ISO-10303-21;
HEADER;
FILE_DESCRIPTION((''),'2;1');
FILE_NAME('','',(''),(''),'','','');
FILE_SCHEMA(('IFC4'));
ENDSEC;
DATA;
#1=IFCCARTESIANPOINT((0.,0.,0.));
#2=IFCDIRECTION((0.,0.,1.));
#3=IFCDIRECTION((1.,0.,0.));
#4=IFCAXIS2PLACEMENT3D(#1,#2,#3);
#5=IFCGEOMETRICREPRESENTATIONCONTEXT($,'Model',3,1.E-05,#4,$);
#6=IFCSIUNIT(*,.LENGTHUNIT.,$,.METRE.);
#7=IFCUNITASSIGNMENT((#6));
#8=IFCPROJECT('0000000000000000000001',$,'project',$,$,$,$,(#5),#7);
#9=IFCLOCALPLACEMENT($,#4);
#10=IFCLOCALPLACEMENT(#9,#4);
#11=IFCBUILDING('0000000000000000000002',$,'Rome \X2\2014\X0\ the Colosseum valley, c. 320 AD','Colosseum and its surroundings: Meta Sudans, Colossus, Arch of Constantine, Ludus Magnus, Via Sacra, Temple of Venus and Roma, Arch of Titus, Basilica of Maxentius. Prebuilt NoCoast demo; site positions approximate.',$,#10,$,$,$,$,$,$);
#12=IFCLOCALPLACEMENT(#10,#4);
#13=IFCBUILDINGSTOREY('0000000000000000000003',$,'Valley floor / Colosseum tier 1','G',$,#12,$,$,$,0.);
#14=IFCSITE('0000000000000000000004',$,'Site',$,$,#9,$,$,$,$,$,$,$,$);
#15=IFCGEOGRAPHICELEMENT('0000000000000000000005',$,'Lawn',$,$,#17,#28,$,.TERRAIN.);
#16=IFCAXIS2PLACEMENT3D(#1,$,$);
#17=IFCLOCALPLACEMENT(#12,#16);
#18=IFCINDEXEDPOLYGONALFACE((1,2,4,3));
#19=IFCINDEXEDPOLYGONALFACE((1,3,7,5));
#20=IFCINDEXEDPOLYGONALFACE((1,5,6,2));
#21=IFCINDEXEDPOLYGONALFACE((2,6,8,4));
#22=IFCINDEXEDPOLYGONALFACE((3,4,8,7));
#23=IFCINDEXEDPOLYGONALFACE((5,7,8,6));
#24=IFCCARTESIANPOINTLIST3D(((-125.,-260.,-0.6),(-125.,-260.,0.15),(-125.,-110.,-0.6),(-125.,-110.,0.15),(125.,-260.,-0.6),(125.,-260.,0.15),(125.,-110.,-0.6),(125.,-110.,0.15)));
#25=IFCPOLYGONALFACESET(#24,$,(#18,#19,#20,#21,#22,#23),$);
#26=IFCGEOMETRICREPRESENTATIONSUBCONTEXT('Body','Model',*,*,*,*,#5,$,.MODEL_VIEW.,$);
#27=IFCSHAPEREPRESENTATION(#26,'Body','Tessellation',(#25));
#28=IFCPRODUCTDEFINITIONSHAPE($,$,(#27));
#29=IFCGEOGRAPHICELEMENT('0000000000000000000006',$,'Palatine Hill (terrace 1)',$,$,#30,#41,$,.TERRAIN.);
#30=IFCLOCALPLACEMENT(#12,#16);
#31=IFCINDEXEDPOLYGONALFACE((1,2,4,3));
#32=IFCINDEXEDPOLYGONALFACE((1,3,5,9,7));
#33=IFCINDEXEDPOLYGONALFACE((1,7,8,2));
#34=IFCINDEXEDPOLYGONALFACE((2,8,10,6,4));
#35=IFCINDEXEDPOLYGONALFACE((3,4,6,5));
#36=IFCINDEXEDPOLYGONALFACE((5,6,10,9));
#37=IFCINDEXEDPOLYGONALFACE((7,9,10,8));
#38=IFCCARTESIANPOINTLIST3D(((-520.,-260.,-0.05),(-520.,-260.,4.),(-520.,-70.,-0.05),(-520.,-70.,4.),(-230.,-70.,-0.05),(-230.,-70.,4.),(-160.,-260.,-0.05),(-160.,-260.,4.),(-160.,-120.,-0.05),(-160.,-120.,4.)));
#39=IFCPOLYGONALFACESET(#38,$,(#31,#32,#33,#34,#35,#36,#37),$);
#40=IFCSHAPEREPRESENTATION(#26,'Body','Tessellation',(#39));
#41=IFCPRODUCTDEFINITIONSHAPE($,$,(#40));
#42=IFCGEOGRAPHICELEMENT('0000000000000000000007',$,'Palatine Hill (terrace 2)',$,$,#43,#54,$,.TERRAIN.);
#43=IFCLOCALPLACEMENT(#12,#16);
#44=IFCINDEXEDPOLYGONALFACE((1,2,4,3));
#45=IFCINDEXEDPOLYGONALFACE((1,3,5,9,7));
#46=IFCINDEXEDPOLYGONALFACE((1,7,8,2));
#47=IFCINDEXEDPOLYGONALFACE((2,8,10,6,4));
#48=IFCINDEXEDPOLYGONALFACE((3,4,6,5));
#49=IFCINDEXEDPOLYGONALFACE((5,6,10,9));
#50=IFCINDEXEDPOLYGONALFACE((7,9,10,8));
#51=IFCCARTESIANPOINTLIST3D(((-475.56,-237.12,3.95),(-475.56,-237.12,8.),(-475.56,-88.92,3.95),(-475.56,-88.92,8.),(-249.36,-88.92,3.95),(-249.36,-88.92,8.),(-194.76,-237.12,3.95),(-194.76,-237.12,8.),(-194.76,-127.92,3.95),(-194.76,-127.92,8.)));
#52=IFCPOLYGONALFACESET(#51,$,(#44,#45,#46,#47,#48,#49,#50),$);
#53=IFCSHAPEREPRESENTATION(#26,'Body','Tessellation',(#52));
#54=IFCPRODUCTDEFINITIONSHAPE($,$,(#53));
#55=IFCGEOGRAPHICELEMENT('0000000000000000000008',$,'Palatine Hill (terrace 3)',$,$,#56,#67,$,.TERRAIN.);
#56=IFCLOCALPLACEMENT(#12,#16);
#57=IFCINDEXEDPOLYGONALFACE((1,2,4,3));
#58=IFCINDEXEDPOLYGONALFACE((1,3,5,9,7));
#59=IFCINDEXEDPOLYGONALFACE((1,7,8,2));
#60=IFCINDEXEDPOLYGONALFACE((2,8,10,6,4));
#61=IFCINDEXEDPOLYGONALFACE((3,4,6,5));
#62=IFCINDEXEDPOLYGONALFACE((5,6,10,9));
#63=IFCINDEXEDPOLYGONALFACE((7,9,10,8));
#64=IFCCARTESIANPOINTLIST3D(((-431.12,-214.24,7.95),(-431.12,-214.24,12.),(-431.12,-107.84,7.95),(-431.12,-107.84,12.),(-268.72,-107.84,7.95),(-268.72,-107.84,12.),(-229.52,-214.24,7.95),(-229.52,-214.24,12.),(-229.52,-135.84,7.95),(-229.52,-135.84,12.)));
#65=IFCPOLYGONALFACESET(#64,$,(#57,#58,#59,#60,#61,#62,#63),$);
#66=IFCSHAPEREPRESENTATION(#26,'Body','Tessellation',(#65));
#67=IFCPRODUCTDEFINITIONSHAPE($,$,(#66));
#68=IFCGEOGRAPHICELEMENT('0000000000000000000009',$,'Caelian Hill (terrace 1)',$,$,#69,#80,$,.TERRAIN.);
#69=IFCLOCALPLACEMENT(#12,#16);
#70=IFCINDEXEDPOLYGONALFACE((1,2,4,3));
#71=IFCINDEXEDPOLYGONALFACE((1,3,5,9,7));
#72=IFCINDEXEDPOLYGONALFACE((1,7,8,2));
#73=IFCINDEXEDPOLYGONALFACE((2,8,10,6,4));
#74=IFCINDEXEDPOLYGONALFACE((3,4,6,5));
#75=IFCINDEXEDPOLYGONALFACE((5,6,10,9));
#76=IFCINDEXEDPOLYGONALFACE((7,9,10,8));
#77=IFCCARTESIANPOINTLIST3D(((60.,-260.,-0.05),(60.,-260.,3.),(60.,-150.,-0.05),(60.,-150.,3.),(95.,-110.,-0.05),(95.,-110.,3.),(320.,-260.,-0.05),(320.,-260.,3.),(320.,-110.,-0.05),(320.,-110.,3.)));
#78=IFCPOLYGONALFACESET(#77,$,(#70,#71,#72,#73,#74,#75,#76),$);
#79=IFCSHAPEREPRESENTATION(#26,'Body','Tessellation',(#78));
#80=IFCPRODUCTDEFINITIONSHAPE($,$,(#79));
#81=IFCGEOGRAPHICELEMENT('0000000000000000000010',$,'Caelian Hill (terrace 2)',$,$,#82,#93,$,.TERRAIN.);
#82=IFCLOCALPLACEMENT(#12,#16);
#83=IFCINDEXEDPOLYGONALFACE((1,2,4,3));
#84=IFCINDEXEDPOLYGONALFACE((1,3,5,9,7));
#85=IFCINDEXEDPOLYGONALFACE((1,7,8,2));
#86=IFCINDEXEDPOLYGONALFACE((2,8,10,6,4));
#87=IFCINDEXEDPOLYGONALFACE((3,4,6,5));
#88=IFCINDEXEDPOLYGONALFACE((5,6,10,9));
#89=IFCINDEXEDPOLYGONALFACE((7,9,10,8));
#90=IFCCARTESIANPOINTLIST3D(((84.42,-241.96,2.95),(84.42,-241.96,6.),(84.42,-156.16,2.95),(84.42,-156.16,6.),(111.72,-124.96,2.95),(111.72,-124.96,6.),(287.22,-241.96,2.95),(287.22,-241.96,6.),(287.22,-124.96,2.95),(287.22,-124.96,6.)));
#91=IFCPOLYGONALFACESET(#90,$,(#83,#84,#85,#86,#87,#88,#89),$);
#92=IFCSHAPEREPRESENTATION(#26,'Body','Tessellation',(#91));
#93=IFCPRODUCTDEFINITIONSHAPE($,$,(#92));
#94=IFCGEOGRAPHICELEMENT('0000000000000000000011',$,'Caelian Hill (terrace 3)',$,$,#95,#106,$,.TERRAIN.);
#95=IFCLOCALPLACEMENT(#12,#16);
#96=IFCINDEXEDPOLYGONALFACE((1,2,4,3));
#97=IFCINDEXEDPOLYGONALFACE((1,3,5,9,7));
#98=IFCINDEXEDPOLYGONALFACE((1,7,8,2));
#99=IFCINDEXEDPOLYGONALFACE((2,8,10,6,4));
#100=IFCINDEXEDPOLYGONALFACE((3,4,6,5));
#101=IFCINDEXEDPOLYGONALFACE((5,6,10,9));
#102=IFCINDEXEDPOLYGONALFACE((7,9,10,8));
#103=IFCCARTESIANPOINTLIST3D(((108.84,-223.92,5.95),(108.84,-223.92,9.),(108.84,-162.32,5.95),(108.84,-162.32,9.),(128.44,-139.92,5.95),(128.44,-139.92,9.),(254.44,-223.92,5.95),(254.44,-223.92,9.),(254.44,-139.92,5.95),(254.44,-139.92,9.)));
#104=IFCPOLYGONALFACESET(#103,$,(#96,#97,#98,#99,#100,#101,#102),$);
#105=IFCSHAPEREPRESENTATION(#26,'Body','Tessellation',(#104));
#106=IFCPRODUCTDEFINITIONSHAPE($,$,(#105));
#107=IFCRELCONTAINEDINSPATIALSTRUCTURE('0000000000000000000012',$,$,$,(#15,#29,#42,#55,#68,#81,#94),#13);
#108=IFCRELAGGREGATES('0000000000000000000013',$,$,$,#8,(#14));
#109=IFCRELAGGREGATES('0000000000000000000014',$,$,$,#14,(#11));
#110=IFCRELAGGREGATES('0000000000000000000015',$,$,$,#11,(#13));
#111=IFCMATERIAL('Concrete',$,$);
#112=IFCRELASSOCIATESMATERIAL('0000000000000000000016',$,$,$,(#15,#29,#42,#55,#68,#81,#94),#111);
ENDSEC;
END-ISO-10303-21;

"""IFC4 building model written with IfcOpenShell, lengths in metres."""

from ifc_helpers import new_model, si_unit, frame, origin_with_axes, place, context, subcontext, project, spatial, indexed_curve, outline, extrude, material, element, save


model = new_model("IFC4")

# Units and contexts
model_context = context("Model", 3, precision=1e-05, world=origin_with_axes())
body_context = subcontext(model_context, "Body", "Model", "MODEL_VIEW")
ifc_project = project(units=[si_unit("LENGTHUNIT", "METRE")], contexts=[model_context])

# Site, building, storey
site_placement = place(None, origin_with_axes())
site = spatial("IfcSite", under=ifc_project, at=site_placement, Name="Site")
building_placement = place(site_placement, origin_with_axes())
building = spatial("IfcBuilding", under=site, at=building_placement, Name="Rome — the Colosseum valley, c. 320 AD", Description="Colosseum and its surroundings: Meta Sudans, Colossus, Arch of Constantine, Ludus Magnus, Via Sacra, Temple of Venus and Roma, Arch of Titus, Basilica of Maxentius. Prebuilt NoCoast demo; site positions approximate.")
storey_placement = place(building_placement, origin_with_axes())
storey = spatial("IfcBuildingStorey", under=building, at=storey_placement, Name="Valley floor / Colosseum tier 1", Description="G", Elevation=0.0)

# Shared definitions
ifc_material_1 = material(Name="Concrete")

# Geographic elements
geographic_element_1_placement = place(storey_placement, frame((0.0, 0.0, -0.6), z_axis=(0.0, 0.0, 1.0), x_axis=(1.0, 0.0, 0.0)))
element("IfcGeographicElement", 1, at=geographic_element_1_placement, inside=storey, material=ifc_material_1, Name="Lawn", PredefinedType="TERRAIN", context=body_context, shape_type="SweptSolid", body=[
    extrude(outline(indexed_curve([(-125.0, -260.0), (125.0, -260.0), (125.0, -110.0), (-125.0, -110.0)])), None, (0.0, 0.0, 1.0), 0.75),
])
geographic_element_2_placement = place(storey_placement, frame((0.0, 0.0, -0.05), z_axis=(0.0, 0.0, 1.0), x_axis=(1.0, 0.0, 0.0)))
element("IfcGeographicElement", 2, at=geographic_element_2_placement, inside=storey, material=ifc_material_1, Name="Palatine Hill (terrace 1)", PredefinedType="TERRAIN", context=body_context, shape_type="SweptSolid", body=[
    extrude(outline(indexed_curve([(-520.0, -260.0), (-160.0, -260.0), (-160.0, -120.0), (-230.0, -70.0), (-520.0, -70.0)])), None, (0.0, 0.0, 1.0), 4.05),
])
geographic_element_3_placement = place(storey_placement, frame((0.0, 0.0, 3.95), z_axis=(0.0, 0.0, 1.0), x_axis=(1.0, 0.0, 0.0)))
element("IfcGeographicElement", 3, at=geographic_element_3_placement, inside=storey, material=ifc_material_1, Name="Palatine Hill (terrace 2)", PredefinedType="TERRAIN", context=body_context, shape_type="SweptSolid", body=[
    extrude(outline(indexed_curve([(-475.56, -237.12), (-194.76, -237.12), (-194.76, -127.92), (-249.36, -88.92), (-475.56, -88.92)])), None, (0.0, 0.0, 1.0), 4.05),
])
geographic_element_4_placement = place(storey_placement, frame((0.0, 0.0, 7.95), z_axis=(0.0, 0.0, 1.0), x_axis=(1.0, 0.0, 0.0)))
element("IfcGeographicElement", 4, at=geographic_element_4_placement, inside=storey, material=ifc_material_1, Name="Palatine Hill (terrace 3)", PredefinedType="TERRAIN", context=body_context, shape_type="SweptSolid", body=[
    extrude(outline(indexed_curve([(-431.12, -214.24), (-229.52, -214.24), (-229.52, -135.84), (-268.72, -107.84), (-431.12, -107.84)])), None, (0.0, 0.0, 1.0), 4.05),
])
geographic_element_5_placement = place(storey_placement, frame((0.0, 0.0, -0.05), z_axis=(0.0, 0.0, 1.0), x_axis=(1.0, 0.0, 0.0)))
element("IfcGeographicElement", 5, at=geographic_element_5_placement, inside=storey, material=ifc_material_1, Name="Caelian Hill (terrace 1)", PredefinedType="TERRAIN", context=body_context, shape_type="SweptSolid", body=[
    extrude(outline(indexed_curve([(60.0, -260.0), (320.0, -260.0), (320.0, -110.0), (95.0, -110.0), (60.0, -150.0)])), None, (0.0, 0.0, 1.0), 3.05),
])
geographic_element_6_placement = place(storey_placement, frame((0.0, 0.0, 2.95), z_axis=(0.0, 0.0, 1.0), x_axis=(1.0, 0.0, 0.0)))
element("IfcGeographicElement", 6, at=geographic_element_6_placement, inside=storey, material=ifc_material_1, Name="Caelian Hill (terrace 2)", PredefinedType="TERRAIN", context=body_context, shape_type="SweptSolid", body=[
    extrude(outline(indexed_curve([(84.42, -241.96), (287.22, -241.96), (287.22, -124.96), (111.72, -124.96), (84.42, -156.16)])), None, (0.0, 0.0, 1.0), 3.05),
])
geographic_element_7_placement = place(storey_placement, frame((0.0, 0.0, 5.95), z_axis=(0.0, 0.0, 1.0), x_axis=(1.0, 0.0, 0.0)))
element("IfcGeographicElement", 7, at=geographic_element_7_placement, inside=storey, material=ifc_material_1, Name="Caelian Hill (terrace 3)", PredefinedType="TERRAIN", context=body_context, shape_type="SweptSolid", body=[
    extrude(outline(indexed_curve([(108.84, -223.92), (254.44, -223.92), (254.44, -139.92), (128.44, -139.92), (108.84, -162.32)])), None, (0.0, 0.0, 1.0), 3.05),
])

save(model, "model.ifc")
